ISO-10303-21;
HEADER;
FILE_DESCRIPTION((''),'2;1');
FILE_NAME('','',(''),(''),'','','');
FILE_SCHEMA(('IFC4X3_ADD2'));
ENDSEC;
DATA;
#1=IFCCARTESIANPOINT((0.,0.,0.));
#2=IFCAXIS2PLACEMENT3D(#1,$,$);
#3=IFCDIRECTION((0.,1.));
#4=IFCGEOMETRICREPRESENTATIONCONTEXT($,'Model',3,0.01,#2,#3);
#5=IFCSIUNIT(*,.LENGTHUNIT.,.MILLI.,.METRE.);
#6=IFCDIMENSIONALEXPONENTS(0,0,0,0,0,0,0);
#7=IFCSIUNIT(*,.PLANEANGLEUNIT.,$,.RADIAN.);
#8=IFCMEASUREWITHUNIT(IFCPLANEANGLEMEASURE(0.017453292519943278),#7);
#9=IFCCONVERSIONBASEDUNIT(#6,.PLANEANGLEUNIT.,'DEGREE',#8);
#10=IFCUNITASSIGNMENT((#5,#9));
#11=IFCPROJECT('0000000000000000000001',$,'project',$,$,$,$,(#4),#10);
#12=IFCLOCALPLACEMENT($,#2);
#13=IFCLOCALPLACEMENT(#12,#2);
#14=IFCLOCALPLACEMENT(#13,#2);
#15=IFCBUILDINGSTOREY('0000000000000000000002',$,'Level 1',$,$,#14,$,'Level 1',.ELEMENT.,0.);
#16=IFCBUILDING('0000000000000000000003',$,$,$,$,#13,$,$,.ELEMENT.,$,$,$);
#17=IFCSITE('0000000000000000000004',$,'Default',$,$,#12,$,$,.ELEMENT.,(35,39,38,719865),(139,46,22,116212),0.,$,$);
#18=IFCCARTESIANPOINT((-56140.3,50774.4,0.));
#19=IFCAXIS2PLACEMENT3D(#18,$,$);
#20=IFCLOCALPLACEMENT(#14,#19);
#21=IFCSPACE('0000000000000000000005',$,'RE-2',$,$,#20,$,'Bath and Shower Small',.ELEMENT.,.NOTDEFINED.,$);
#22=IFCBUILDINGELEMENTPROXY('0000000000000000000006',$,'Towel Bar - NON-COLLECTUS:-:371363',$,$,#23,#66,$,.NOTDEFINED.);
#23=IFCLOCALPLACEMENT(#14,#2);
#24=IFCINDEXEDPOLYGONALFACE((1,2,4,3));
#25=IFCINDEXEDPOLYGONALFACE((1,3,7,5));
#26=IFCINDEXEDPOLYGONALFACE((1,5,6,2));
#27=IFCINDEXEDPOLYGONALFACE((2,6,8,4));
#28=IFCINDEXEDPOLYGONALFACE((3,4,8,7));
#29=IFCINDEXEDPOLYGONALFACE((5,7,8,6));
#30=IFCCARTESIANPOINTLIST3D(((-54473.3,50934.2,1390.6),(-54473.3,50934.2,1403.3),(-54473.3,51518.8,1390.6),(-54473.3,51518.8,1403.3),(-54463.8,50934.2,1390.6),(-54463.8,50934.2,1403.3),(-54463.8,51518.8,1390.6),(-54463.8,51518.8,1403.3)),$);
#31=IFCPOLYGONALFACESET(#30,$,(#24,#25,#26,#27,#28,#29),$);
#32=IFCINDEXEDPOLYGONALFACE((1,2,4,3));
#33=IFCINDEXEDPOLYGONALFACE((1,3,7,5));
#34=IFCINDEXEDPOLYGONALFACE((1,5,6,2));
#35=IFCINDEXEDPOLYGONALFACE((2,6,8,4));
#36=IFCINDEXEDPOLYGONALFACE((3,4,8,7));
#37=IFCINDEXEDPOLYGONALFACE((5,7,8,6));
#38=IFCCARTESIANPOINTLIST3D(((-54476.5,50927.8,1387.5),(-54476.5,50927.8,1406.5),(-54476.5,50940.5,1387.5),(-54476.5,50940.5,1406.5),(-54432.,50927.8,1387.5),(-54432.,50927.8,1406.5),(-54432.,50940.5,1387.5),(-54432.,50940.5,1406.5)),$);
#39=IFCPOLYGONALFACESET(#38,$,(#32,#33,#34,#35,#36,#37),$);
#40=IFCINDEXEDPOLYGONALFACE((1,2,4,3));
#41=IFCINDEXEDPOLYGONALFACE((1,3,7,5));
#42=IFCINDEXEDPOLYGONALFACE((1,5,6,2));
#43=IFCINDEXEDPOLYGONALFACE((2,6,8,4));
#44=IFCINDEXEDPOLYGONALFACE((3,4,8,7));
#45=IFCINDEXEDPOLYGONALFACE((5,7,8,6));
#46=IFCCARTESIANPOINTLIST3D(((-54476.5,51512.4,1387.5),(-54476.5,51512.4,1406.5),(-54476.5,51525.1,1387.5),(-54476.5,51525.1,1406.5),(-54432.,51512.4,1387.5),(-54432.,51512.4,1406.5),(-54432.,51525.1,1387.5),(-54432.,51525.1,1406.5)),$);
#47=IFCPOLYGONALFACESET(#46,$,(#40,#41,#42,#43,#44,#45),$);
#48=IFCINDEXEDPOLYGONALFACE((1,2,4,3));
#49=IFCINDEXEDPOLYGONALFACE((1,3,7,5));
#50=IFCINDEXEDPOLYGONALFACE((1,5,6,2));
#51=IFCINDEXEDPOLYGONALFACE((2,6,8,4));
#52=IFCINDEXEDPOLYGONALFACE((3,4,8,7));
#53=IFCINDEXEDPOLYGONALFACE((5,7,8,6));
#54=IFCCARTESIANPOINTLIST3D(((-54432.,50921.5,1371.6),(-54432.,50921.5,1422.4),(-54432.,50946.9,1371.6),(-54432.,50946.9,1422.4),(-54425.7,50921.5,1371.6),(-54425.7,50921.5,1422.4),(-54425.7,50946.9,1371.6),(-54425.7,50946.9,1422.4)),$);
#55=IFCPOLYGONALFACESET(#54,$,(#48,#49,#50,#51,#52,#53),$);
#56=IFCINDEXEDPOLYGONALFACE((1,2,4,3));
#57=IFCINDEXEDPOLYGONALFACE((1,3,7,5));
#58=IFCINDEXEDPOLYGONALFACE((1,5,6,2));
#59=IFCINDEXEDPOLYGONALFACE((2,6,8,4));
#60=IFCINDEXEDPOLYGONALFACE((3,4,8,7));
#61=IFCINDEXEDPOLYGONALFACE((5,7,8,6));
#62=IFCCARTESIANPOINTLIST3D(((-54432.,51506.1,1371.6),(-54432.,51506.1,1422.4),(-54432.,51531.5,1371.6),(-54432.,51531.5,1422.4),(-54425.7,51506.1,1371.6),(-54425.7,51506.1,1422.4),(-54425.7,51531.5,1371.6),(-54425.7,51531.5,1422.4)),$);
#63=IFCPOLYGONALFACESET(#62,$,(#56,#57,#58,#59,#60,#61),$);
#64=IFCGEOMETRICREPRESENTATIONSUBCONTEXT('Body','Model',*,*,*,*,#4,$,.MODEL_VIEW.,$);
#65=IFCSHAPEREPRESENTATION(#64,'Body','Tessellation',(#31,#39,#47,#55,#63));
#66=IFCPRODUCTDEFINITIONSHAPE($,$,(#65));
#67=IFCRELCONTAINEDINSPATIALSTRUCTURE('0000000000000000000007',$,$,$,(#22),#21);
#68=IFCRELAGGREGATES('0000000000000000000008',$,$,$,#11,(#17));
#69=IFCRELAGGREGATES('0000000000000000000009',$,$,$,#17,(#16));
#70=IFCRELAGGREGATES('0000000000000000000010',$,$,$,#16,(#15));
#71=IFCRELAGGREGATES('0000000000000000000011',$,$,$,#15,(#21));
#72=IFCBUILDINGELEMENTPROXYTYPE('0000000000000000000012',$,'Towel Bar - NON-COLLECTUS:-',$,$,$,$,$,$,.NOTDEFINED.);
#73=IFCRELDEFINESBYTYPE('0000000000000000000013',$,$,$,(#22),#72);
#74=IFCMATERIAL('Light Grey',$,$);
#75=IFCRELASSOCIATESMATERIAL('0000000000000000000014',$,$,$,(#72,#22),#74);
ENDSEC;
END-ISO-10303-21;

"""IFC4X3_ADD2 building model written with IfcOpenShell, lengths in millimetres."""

from ifc_helpers import new_model, entity, si_unit, converted_unit, direction, frame, frame_2d, origin, origin_2d_with_axis, place, context, subcontext, project, spatial, rectangle, extrude, source, transform, mapped, material, type_object, type_shapes, element, save


model = new_model("IFC4X3_ADD2")

# Units and contexts
model_context = context("Model", 3, precision=0.01, world=origin(), true_north=direction((0.0, 1.0)))
body_context = subcontext(model_context, "Body", "Model", "MODEL_VIEW")
ifc_project = project(units=[si_unit("LENGTHUNIT", "METRE", prefix="MILLI"), converted_unit("PLANEANGLEUNIT", "DEGREE", entity("IfcPlaneAngleMeasure", 0.017453292519943278), si_unit("PLANEANGLEUNIT", "RADIAN"), dimensions=[0, 0, 0, 0, 0, 0, 0])], contexts=[model_context])

# Site, building, storey
site_placement = place(None, origin())
site = spatial("IfcSite", under=ifc_project, at=site_placement, Name="Default", CompositionType="ELEMENT", RefLatitude=(35, 39, 38, 719865), RefLongitude=(139, 46, 22, 116212), RefElevation=0.0)
building_placement = place(site_placement, origin())
building = spatial("IfcBuilding", under=site, at=building_placement, CompositionType="ELEMENT")
storey_placement = place(building_placement, origin())
storey = spatial("IfcBuildingStorey", under=building, at=storey_placement, Name="Level 1", LongName="Level 1", CompositionType="ELEMENT", Elevation=0.0)

# Shared definitions
space_1_placement = place(storey_placement, frame((-56140.3, 50774.4, 0.0)))
space_1 = spatial("IfcSpace", under=storey, at=space_1_placement, Name="RE-2", LongName="Bath and Shower Small", CompositionType="ELEMENT", PredefinedType="NOTDEFINED")

# Building element proxy
ifc_material_1 = material(Name="Light Grey")
building_element_proxy_type_1 = type_object("IfcBuildingElementProxyType", Name="Towel Bar - NON-COLLECTUS:-", PredefinedType="NOTDEFINED", material=ifc_material_1)
shared_shape_1 = source(origin(), body_context, "Body", "SweptSolid", [
    extrude(rectangle(XDim=584.6, YDim=9.5, at=origin_2d_with_axis()), frame((0.0, -42.9, 19.1), z_axis=(0.0, 0.0, 1.0), x_axis=(-1.0, 0.0, 0.0)), (0.0, 0.0, 1.0), 12.7),
    extrude(rectangle(XDim=44.5, YDim=12.7, at=frame_2d((0.0, 0.0), x_axis=(1.0, 0.0))), frame((292.3, -28.6, 15.9), z_axis=(0.0, 0.0, 1.0), x_axis=(0.0, -1.0, 0.0)), (0.0, 0.0, 1.0), 19.1),
    extrude(rectangle(XDim=44.5, YDim=12.7, at=origin_2d_with_axis()), frame((-292.3, -28.6, 15.9), z_axis=(0.0, 0.0, 1.0), x_axis=(0.0, -1.0, 0.0)), (0.0, 0.0, 1.0), 19.1),
    extrude(rectangle(XDim=6.3, YDim=25.4, at=frame_2d((0.0, 0.0), x_axis=(1.0, 0.0))), frame((292.3, -3.2, 0.0), z_axis=(0.0, 0.0, 1.0), x_axis=(0.0, -1.0, 0.0)), (0.0, 0.0, 1.0), 50.8),
    extrude(rectangle(XDim=6.3, YDim=25.4, at=frame_2d((0.0, 0.0), x_axis=(1.0, 0.0))), frame((-292.3, -3.2, 0.0), z_axis=(0.0, 0.0, 1.0), x_axis=(0.0, -1.0, 0.0)), (0.0, 0.0, 1.0), 50.8),
])
type_shapes(building_element_proxy_type_1, [shared_shape_1])
proxy_1_placement = place(space_1_placement, frame((1714.6, 452.0, 1371.6), z_axis=(0.0, 0.0, 1.0), x_axis=(0.000001, -1.0, 0.0)))
element("IfcBuildingElementProxy", 1, at=proxy_1_placement, inside=space_1, type_object=building_element_proxy_type_1, material=ifc_material_1, Name="Towel Bar - NON-COLLECTUS:-:371363", PredefinedType="NOTDEFINED", context=body_context, shape_type="MappedRepresentation", body=[
    mapped(shared_shape_1, transform((0.0, 0.0, 0.0), scale=1.0)),
])

save(model, "model.ifc")
